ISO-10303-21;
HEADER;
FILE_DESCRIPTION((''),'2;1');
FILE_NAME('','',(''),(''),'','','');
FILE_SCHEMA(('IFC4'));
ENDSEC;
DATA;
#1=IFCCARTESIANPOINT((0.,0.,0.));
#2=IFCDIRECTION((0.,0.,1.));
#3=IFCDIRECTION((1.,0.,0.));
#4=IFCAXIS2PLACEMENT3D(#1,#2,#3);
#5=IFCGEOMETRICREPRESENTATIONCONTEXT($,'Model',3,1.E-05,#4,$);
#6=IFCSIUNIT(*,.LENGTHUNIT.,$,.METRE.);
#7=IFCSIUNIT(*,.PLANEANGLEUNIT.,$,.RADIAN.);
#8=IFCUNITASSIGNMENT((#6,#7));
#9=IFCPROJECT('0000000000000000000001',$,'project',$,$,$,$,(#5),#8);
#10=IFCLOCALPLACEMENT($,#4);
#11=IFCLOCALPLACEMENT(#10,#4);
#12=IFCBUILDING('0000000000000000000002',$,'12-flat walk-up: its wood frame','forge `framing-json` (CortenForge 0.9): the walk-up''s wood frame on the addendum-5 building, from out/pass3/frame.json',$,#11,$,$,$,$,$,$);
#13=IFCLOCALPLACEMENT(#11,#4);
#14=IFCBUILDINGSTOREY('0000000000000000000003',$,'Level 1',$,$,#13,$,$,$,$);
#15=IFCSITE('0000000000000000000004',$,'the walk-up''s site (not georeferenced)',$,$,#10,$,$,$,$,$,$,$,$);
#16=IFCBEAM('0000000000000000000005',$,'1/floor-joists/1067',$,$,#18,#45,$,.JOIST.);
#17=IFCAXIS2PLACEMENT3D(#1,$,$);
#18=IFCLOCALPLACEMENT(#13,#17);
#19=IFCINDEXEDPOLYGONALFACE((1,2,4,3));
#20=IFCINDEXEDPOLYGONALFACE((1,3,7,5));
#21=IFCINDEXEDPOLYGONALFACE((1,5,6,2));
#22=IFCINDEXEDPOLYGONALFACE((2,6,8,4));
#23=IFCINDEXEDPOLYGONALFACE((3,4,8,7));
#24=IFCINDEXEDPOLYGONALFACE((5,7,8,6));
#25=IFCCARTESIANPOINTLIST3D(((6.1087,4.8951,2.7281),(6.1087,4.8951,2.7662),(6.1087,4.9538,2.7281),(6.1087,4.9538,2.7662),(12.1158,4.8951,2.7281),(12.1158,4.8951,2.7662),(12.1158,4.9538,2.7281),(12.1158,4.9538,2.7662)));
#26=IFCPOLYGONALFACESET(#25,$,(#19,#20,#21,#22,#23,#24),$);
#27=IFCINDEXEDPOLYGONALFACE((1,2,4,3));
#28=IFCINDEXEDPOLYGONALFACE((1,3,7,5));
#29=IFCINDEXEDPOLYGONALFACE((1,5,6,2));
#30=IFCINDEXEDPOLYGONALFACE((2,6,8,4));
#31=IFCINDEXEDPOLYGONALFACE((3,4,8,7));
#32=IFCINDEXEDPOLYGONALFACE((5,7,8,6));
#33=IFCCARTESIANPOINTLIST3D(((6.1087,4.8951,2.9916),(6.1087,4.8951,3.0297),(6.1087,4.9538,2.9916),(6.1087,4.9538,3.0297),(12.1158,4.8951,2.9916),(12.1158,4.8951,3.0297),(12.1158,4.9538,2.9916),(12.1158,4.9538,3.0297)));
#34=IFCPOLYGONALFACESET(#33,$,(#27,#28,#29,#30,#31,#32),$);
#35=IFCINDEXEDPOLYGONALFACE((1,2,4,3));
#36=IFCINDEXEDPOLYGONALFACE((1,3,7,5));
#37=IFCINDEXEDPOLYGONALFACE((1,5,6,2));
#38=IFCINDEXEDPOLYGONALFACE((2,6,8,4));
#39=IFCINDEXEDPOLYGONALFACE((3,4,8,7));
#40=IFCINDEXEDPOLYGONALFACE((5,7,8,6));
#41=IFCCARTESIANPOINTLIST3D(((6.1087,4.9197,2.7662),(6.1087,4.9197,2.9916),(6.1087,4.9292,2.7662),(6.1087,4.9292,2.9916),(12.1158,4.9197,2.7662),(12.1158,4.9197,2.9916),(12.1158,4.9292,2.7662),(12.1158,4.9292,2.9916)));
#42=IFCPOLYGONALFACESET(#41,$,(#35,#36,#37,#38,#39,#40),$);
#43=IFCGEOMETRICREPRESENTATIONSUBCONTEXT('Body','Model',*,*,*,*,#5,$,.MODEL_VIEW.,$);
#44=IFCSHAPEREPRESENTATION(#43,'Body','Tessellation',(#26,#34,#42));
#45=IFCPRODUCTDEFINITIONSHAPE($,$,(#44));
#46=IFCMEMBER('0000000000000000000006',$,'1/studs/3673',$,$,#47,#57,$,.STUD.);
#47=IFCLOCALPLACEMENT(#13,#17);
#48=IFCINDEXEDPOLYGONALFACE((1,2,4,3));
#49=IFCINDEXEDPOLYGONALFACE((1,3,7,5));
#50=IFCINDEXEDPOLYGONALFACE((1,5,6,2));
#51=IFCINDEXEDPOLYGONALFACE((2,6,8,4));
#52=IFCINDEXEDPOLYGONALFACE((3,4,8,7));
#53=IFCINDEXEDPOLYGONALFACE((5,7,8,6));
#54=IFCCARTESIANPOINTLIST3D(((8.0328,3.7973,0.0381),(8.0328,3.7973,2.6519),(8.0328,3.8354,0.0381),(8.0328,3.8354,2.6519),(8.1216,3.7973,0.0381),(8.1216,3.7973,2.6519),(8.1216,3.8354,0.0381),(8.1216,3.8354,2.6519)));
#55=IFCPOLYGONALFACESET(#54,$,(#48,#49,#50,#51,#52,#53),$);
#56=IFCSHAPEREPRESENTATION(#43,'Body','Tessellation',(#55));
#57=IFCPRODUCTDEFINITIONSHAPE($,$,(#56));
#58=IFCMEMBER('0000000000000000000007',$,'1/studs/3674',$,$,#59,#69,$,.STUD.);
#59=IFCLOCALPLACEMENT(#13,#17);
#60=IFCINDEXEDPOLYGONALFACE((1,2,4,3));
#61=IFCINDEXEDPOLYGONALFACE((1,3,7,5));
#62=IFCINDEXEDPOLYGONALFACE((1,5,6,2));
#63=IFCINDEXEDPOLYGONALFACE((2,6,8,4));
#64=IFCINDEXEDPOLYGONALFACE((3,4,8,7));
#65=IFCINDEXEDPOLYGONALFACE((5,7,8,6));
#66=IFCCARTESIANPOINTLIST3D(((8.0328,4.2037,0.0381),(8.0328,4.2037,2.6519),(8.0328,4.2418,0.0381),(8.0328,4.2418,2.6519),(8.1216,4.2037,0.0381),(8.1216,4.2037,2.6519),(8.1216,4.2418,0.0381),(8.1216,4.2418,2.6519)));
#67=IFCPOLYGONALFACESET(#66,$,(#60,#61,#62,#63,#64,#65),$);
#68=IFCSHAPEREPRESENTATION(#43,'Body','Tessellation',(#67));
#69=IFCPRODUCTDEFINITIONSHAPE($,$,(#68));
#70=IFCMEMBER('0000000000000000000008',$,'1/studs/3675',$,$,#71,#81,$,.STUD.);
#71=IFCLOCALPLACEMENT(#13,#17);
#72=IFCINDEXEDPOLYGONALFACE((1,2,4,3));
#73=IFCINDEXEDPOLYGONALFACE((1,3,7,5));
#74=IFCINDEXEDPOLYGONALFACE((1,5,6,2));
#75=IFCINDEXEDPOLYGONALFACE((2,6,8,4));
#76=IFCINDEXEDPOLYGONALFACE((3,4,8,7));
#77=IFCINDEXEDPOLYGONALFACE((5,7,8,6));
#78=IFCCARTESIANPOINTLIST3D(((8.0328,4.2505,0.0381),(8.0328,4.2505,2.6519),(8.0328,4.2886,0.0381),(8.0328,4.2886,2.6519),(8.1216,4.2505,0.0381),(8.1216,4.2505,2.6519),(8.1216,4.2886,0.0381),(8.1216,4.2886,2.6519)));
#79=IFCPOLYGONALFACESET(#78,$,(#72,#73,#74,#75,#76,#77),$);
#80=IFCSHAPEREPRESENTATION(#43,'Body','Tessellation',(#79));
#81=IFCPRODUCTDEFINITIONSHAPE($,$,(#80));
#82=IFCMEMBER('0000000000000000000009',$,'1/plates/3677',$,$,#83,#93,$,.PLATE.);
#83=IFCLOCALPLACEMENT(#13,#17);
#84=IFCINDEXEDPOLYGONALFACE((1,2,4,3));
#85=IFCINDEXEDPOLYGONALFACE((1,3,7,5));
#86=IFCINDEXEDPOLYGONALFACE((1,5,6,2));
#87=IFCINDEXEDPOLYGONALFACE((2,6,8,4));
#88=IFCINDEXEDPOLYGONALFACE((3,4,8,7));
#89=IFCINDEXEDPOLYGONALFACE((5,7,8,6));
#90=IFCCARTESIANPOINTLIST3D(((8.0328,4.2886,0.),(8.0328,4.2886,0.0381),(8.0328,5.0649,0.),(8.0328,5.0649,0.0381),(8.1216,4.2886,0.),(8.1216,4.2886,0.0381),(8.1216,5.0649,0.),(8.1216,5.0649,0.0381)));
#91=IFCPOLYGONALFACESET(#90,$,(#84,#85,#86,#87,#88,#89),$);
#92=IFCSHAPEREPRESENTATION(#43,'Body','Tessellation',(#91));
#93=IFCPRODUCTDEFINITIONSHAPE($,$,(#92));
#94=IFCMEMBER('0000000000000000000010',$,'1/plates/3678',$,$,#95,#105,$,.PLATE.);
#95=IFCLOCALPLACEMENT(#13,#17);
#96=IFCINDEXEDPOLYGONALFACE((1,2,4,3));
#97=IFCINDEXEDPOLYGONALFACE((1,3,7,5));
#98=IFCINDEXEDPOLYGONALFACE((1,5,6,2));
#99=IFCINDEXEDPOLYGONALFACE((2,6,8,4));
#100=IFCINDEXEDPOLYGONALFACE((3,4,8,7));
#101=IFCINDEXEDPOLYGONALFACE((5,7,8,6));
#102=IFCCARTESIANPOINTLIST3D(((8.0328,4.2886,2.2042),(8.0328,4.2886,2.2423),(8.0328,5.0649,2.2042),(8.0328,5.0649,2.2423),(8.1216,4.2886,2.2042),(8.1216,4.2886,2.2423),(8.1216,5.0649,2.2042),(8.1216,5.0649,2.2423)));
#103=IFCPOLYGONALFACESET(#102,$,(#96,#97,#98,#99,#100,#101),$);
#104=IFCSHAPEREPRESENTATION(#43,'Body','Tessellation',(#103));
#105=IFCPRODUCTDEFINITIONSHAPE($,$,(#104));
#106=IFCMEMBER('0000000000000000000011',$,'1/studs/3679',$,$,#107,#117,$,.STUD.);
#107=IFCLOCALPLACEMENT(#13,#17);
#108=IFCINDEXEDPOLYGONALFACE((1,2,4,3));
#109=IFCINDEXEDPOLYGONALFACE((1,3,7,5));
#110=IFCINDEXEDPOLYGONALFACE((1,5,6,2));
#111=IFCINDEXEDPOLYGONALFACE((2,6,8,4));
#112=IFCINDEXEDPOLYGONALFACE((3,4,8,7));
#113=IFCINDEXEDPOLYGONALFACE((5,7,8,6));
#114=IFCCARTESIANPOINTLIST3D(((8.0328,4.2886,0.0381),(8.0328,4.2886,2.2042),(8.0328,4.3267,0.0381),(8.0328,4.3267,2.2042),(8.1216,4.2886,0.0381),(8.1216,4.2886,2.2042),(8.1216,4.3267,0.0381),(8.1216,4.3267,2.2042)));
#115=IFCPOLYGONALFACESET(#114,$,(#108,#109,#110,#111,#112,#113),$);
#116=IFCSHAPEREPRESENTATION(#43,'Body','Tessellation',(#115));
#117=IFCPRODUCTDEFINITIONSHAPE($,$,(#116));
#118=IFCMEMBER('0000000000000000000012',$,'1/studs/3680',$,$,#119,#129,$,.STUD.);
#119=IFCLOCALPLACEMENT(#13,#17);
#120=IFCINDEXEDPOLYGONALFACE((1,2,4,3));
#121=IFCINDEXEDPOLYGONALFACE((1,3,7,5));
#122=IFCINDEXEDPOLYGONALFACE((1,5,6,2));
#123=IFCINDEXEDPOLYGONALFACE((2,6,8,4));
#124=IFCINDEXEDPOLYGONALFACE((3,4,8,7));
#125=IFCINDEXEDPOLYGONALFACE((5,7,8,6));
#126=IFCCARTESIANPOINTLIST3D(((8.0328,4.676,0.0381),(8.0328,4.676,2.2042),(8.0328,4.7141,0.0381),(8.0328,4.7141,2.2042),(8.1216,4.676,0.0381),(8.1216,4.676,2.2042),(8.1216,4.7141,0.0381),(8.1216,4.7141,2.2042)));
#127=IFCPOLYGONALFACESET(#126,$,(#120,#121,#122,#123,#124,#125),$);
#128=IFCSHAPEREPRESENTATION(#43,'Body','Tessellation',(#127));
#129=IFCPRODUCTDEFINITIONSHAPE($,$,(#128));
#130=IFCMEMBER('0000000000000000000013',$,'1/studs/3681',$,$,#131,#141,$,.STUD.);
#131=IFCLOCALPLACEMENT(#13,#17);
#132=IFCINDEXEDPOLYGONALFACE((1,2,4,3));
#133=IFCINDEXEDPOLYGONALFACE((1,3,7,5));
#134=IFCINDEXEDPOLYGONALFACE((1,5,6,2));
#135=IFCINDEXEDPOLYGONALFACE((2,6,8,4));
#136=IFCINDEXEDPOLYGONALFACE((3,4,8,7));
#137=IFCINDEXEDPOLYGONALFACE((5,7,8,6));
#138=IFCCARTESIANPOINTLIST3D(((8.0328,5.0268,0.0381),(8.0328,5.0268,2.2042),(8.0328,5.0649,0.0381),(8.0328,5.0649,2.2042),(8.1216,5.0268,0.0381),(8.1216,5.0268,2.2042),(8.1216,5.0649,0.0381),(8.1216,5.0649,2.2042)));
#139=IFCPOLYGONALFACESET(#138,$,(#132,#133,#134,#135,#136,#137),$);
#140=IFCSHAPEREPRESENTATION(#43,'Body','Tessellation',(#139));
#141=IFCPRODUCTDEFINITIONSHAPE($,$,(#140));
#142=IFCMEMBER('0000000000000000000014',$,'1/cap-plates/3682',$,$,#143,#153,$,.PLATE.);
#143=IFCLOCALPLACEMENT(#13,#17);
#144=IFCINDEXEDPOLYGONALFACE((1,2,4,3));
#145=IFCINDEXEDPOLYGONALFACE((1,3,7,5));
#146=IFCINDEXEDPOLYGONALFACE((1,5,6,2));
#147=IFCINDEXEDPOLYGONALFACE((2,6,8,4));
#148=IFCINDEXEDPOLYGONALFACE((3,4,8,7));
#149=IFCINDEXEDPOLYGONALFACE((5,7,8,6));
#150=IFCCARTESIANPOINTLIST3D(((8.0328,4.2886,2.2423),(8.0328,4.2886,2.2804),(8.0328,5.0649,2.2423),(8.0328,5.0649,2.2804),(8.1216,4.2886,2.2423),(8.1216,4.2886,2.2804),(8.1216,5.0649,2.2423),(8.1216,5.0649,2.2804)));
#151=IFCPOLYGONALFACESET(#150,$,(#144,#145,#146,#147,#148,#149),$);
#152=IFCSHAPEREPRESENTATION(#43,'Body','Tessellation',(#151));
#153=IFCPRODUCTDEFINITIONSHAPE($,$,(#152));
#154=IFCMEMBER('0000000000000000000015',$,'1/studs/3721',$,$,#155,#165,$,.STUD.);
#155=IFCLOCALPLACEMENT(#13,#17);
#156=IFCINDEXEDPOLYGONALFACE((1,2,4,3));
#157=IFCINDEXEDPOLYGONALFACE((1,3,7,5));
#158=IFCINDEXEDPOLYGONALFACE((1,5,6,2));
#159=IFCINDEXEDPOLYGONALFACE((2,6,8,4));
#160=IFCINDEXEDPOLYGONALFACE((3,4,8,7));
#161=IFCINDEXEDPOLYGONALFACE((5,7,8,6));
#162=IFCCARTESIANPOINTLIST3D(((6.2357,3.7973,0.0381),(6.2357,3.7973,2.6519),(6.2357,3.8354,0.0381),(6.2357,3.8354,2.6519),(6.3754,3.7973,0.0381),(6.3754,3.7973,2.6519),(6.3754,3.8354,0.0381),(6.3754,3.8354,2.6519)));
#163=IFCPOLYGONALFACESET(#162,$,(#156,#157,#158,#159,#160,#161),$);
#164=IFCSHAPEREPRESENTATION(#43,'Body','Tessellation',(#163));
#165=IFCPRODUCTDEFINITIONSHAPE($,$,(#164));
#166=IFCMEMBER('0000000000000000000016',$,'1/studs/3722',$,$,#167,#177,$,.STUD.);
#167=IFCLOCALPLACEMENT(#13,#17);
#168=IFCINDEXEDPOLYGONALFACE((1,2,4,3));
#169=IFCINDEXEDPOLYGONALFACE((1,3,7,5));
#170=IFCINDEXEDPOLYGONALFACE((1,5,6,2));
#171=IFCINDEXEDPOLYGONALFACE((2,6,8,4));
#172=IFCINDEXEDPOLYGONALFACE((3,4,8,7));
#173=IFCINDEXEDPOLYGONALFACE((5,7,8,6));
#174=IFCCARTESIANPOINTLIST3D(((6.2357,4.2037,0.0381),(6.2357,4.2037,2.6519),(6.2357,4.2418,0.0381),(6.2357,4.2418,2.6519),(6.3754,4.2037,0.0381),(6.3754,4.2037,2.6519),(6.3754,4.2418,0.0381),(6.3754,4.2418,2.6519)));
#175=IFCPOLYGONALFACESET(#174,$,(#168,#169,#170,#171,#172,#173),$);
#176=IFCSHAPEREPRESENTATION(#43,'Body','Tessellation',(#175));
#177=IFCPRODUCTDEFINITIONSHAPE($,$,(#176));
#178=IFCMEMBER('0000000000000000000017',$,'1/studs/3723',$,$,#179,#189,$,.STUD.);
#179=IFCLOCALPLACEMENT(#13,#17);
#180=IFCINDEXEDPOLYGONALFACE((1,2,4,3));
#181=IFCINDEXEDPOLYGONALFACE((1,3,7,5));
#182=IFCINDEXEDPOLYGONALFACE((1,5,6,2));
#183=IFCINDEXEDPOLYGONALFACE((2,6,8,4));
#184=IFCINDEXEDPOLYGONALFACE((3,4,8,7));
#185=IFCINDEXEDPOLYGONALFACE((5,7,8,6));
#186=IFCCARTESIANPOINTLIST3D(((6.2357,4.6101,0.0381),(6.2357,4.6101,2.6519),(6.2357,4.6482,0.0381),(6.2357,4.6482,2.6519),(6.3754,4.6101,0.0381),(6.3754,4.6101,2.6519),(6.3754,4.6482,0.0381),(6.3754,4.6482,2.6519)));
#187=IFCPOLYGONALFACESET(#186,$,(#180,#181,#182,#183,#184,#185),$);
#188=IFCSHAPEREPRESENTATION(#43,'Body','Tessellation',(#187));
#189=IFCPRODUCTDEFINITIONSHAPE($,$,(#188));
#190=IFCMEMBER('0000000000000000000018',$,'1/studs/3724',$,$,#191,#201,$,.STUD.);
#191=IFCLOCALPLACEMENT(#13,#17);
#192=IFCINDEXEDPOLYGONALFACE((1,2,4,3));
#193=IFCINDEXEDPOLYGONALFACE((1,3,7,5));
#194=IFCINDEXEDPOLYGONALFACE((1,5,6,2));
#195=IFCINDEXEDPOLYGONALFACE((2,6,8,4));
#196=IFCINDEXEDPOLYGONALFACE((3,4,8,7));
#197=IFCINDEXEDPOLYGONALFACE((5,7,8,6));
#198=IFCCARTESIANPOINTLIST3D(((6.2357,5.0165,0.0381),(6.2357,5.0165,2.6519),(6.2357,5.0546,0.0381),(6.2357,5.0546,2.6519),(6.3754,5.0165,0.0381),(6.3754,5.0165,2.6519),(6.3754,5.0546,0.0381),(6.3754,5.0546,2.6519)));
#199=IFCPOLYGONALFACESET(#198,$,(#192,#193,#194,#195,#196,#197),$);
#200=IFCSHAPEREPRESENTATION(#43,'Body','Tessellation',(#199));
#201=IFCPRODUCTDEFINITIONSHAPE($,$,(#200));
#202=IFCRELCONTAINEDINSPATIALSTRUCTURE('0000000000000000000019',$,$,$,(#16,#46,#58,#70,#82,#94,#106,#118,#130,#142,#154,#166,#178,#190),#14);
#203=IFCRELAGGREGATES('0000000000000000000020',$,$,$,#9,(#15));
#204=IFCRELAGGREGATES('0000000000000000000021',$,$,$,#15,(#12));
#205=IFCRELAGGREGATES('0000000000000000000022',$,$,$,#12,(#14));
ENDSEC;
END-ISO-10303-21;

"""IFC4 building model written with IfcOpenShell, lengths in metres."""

from ifc_helpers import new_model, si_unit, frame, frame_2d, origin, origin_with_axes, place, context, subcontext, project, spatial, rectangle, extrude, element, save


model = new_model("IFC4")

# Units and contexts
model_context = context("Model", 3, precision=1e-05, world=origin_with_axes())
body_context = subcontext(model_context, "Body", "Model", "MODEL_VIEW")
ifc_project = project(units=[si_unit("LENGTHUNIT", "METRE"), si_unit("PLANEANGLEUNIT", "RADIAN")], contexts=[model_context])

# Site, building, storey
site_placement = place(None, origin_with_axes())
site = spatial("IfcSite", under=ifc_project, at=site_placement, Name="the walk-up's site (not georeferenced)")
building_placement = place(site_placement, origin_with_axes())
building = spatial("IfcBuilding", under=site, at=building_placement, Name="12-flat walk-up: its wood frame", Description="forge `framing-json` (CortenForge 0.9): the walk-up's wood frame on the addendum-5 building, from out/pass3/frame.json")
storey_placement = place(building_placement, origin_with_axes())
storey = spatial("IfcBuildingStorey", under=building, at=storey_placement, Name="Level 1")

# Beam
beam_1_placement = place(storey_placement, frame((6.1087, 4.8951, 2.7281), z_axis=(0.0, 0.0, 1.0), x_axis=(1.0, 0.0, 0.0)))
element("IfcBeam", 1, at=beam_1_placement, inside=storey, Name="1/floor-joists/1067", PredefinedType="JOIST", context=body_context, shape_type="SweptSolid", body=[
    extrude(rectangle(XDim=6.0071, YDim=0.0587, at=frame_2d((3.0036, 0.0294))), origin(), (0.0, 0.0, 1.0), 0.0381),
    extrude(rectangle(XDim=6.0071, YDim=0.0587, at=frame_2d((3.0036, 0.0294))), frame((0.0, 0.0, 0.2635)), (0.0, 0.0, 1.0), 0.0381),
    extrude(rectangle(XDim=6.0071, YDim=0.0095, at=frame_2d((3.0036, 0.0048))), frame((0.0, 0.0246, 0.0381)), (0.0, 0.0, 1.0), 0.2254),
])

# Members
member_1_placement = place(storey_placement, frame((8.0328, 3.7973, 0.0381), z_axis=(0.0, 0.0, 1.0), x_axis=(1.0, 0.0, 0.0)))
element("IfcMember", 2, at=member_1_placement, inside=storey, Name="1/studs/3673", PredefinedType="STUD", context=body_context, shape_type="SweptSolid", body=[
    extrude(rectangle(XDim=0.0889, YDim=0.0381, at=frame_2d((0.0445, 0.0191))), origin(), (0.0, 0.0, 1.0), 2.6138),
])
member_2_placement = place(storey_placement, frame((8.0328, 4.2037, 0.0381), z_axis=(0.0, 0.0, 1.0), x_axis=(1.0, 0.0, 0.0)))
element("IfcMember", 3, at=member_2_placement, inside=storey, Name="1/studs/3674", PredefinedType="STUD", context=body_context, shape_type="SweptSolid", body=[
    extrude(rectangle(XDim=0.0889, YDim=0.0381, at=frame_2d((0.0445, 0.019))), origin(), (0.0, 0.0, 1.0), 2.6138),
])
member_3_placement = place(storey_placement, frame((8.0328, 4.2505, 0.0381), z_axis=(0.0, 0.0, 1.0), x_axis=(1.0, 0.0, 0.0)))
element("IfcMember", 4, at=member_3_placement, inside=storey, Name="1/studs/3675", PredefinedType="STUD", context=body_context, shape_type="SweptSolid", body=[
    extrude(rectangle(XDim=0.0889, YDim=0.0381, at=frame_2d((0.0445, 0.0191))), origin(), (0.0, 0.0, 1.0), 2.6138),
])
member_4_placement = place(storey_placement, frame((8.0328, 4.2886, 0.0), z_axis=(0.0, 0.0, 1.0), x_axis=(1.0, 0.0, 0.0)))
element("IfcMember", 5, at=member_4_placement, inside=storey, Name="1/plates/3677", PredefinedType="PLATE", context=body_context, shape_type="SweptSolid", body=[
    extrude(rectangle(XDim=0.0889, YDim=0.7763, at=frame_2d((0.0445, 0.3881))), origin(), (0.0, 0.0, 1.0), 0.0381),
])
member_5_placement = place(storey_placement, frame((8.0328, 4.2886, 2.2042), z_axis=(0.0, 0.0, 1.0), x_axis=(1.0, 0.0, 0.0)))
element("IfcMember", 6, at=member_5_placement, inside=storey, Name="1/plates/3678", PredefinedType="PLATE", context=body_context, shape_type="SweptSolid", body=[
    extrude(rectangle(XDim=0.0889, YDim=0.7763, at=frame_2d((0.0445, 0.3881))), origin(), (0.0, 0.0, 1.0), 0.0381),
])
for number, where, z_axis, x_axis, name in (
    (7, (8.0328, 4.2886, 0.0381), (0.0, 0.0, 1.0), (1.0, 0.0, 0.0), "1/studs/3679"),
    (8, (8.0328, 4.676, 0.0381), (0.0, 0.0, 1.0), (1.0, 0.0, 0.0), "1/studs/3680"),
    (9, (8.0328, 5.0268, 0.0381), (0.0, 0.0, 1.0), (1.0, 0.0, 0.0), "1/studs/3681"),
):
    element("IfcMember", number, at=place(storey_placement, frame(where, z_axis=z_axis, x_axis=x_axis)), inside=storey, Name=name, PredefinedType="STUD", context=body_context, shape_type="SweptSolid", body=[
        extrude(rectangle(XDim=0.0889, YDim=0.0381, at=frame_2d((0.0445, 0.0191))), origin(), (0.0, 0.0, 1.0), 2.1661),
    ])
member_6_placement = place(storey_placement, frame((8.0328, 4.2886, 2.2423), z_axis=(0.0, 0.0, 1.0), x_axis=(1.0, 0.0, 0.0)))
element("IfcMember", 10, at=member_6_placement, inside=storey, Name="1/cap-plates/3682", PredefinedType="PLATE", context=body_context, shape_type="SweptSolid", body=[
    extrude(rectangle(XDim=0.0889, YDim=0.7763, at=frame_2d((0.0445, 0.3881))), origin(), (0.0, 0.0, 1.0), 0.0381),
])
member_7_placement = place(storey_placement, frame((6.2357, 3.7973, 0.0381), z_axis=(0.0, 0.0, 1.0), x_axis=(1.0, 0.0, 0.0)))
element("IfcMember", 11, at=member_7_placement, inside=storey, Name="1/studs/3721", PredefinedType="STUD", context=body_context, shape_type="SweptSolid", body=[
    extrude(rectangle(XDim=0.1397, YDim=0.0381, at=frame_2d((0.0699, 0.0191))), origin(), (0.0, 0.0, 1.0), 2.6138),
])
member_8_placement = place(storey_placement, frame((6.2357, 4.2037, 0.0381), z_axis=(0.0, 0.0, 1.0), x_axis=(1.0, 0.0, 0.0)))
element("IfcMember", 12, at=member_8_placement, inside=storey, Name="1/studs/3722", PredefinedType="STUD", context=body_context, shape_type="SweptSolid", body=[
    extrude(rectangle(XDim=0.1397, YDim=0.0381, at=frame_2d((0.0699, 0.019))), origin(), (0.0, 0.0, 1.0), 2.6138),
])
for number, where, z_axis, x_axis, name in (
    (13, (6.2357, 4.6101, 0.0381), (0.0, 0.0, 1.0), (1.0, 0.0, 0.0), "1/studs/3723"),
    (14, (6.2357, 5.0165, 0.0381), (0.0, 0.0, 1.0), (1.0, 0.0, 0.0), "1/studs/3724"),
):
    element("IfcMember", number, at=place(storey_placement, frame(where, z_axis=z_axis, x_axis=x_axis)), inside=storey, Name=name, PredefinedType="STUD", context=body_context, shape_type="SweptSolid", body=[
        extrude(rectangle(XDim=0.1397, YDim=0.0381, at=frame_2d((0.0699, 0.0191))), origin(), (0.0, 0.0, 1.0), 2.6138),
    ])

save(model, "model.ifc")
